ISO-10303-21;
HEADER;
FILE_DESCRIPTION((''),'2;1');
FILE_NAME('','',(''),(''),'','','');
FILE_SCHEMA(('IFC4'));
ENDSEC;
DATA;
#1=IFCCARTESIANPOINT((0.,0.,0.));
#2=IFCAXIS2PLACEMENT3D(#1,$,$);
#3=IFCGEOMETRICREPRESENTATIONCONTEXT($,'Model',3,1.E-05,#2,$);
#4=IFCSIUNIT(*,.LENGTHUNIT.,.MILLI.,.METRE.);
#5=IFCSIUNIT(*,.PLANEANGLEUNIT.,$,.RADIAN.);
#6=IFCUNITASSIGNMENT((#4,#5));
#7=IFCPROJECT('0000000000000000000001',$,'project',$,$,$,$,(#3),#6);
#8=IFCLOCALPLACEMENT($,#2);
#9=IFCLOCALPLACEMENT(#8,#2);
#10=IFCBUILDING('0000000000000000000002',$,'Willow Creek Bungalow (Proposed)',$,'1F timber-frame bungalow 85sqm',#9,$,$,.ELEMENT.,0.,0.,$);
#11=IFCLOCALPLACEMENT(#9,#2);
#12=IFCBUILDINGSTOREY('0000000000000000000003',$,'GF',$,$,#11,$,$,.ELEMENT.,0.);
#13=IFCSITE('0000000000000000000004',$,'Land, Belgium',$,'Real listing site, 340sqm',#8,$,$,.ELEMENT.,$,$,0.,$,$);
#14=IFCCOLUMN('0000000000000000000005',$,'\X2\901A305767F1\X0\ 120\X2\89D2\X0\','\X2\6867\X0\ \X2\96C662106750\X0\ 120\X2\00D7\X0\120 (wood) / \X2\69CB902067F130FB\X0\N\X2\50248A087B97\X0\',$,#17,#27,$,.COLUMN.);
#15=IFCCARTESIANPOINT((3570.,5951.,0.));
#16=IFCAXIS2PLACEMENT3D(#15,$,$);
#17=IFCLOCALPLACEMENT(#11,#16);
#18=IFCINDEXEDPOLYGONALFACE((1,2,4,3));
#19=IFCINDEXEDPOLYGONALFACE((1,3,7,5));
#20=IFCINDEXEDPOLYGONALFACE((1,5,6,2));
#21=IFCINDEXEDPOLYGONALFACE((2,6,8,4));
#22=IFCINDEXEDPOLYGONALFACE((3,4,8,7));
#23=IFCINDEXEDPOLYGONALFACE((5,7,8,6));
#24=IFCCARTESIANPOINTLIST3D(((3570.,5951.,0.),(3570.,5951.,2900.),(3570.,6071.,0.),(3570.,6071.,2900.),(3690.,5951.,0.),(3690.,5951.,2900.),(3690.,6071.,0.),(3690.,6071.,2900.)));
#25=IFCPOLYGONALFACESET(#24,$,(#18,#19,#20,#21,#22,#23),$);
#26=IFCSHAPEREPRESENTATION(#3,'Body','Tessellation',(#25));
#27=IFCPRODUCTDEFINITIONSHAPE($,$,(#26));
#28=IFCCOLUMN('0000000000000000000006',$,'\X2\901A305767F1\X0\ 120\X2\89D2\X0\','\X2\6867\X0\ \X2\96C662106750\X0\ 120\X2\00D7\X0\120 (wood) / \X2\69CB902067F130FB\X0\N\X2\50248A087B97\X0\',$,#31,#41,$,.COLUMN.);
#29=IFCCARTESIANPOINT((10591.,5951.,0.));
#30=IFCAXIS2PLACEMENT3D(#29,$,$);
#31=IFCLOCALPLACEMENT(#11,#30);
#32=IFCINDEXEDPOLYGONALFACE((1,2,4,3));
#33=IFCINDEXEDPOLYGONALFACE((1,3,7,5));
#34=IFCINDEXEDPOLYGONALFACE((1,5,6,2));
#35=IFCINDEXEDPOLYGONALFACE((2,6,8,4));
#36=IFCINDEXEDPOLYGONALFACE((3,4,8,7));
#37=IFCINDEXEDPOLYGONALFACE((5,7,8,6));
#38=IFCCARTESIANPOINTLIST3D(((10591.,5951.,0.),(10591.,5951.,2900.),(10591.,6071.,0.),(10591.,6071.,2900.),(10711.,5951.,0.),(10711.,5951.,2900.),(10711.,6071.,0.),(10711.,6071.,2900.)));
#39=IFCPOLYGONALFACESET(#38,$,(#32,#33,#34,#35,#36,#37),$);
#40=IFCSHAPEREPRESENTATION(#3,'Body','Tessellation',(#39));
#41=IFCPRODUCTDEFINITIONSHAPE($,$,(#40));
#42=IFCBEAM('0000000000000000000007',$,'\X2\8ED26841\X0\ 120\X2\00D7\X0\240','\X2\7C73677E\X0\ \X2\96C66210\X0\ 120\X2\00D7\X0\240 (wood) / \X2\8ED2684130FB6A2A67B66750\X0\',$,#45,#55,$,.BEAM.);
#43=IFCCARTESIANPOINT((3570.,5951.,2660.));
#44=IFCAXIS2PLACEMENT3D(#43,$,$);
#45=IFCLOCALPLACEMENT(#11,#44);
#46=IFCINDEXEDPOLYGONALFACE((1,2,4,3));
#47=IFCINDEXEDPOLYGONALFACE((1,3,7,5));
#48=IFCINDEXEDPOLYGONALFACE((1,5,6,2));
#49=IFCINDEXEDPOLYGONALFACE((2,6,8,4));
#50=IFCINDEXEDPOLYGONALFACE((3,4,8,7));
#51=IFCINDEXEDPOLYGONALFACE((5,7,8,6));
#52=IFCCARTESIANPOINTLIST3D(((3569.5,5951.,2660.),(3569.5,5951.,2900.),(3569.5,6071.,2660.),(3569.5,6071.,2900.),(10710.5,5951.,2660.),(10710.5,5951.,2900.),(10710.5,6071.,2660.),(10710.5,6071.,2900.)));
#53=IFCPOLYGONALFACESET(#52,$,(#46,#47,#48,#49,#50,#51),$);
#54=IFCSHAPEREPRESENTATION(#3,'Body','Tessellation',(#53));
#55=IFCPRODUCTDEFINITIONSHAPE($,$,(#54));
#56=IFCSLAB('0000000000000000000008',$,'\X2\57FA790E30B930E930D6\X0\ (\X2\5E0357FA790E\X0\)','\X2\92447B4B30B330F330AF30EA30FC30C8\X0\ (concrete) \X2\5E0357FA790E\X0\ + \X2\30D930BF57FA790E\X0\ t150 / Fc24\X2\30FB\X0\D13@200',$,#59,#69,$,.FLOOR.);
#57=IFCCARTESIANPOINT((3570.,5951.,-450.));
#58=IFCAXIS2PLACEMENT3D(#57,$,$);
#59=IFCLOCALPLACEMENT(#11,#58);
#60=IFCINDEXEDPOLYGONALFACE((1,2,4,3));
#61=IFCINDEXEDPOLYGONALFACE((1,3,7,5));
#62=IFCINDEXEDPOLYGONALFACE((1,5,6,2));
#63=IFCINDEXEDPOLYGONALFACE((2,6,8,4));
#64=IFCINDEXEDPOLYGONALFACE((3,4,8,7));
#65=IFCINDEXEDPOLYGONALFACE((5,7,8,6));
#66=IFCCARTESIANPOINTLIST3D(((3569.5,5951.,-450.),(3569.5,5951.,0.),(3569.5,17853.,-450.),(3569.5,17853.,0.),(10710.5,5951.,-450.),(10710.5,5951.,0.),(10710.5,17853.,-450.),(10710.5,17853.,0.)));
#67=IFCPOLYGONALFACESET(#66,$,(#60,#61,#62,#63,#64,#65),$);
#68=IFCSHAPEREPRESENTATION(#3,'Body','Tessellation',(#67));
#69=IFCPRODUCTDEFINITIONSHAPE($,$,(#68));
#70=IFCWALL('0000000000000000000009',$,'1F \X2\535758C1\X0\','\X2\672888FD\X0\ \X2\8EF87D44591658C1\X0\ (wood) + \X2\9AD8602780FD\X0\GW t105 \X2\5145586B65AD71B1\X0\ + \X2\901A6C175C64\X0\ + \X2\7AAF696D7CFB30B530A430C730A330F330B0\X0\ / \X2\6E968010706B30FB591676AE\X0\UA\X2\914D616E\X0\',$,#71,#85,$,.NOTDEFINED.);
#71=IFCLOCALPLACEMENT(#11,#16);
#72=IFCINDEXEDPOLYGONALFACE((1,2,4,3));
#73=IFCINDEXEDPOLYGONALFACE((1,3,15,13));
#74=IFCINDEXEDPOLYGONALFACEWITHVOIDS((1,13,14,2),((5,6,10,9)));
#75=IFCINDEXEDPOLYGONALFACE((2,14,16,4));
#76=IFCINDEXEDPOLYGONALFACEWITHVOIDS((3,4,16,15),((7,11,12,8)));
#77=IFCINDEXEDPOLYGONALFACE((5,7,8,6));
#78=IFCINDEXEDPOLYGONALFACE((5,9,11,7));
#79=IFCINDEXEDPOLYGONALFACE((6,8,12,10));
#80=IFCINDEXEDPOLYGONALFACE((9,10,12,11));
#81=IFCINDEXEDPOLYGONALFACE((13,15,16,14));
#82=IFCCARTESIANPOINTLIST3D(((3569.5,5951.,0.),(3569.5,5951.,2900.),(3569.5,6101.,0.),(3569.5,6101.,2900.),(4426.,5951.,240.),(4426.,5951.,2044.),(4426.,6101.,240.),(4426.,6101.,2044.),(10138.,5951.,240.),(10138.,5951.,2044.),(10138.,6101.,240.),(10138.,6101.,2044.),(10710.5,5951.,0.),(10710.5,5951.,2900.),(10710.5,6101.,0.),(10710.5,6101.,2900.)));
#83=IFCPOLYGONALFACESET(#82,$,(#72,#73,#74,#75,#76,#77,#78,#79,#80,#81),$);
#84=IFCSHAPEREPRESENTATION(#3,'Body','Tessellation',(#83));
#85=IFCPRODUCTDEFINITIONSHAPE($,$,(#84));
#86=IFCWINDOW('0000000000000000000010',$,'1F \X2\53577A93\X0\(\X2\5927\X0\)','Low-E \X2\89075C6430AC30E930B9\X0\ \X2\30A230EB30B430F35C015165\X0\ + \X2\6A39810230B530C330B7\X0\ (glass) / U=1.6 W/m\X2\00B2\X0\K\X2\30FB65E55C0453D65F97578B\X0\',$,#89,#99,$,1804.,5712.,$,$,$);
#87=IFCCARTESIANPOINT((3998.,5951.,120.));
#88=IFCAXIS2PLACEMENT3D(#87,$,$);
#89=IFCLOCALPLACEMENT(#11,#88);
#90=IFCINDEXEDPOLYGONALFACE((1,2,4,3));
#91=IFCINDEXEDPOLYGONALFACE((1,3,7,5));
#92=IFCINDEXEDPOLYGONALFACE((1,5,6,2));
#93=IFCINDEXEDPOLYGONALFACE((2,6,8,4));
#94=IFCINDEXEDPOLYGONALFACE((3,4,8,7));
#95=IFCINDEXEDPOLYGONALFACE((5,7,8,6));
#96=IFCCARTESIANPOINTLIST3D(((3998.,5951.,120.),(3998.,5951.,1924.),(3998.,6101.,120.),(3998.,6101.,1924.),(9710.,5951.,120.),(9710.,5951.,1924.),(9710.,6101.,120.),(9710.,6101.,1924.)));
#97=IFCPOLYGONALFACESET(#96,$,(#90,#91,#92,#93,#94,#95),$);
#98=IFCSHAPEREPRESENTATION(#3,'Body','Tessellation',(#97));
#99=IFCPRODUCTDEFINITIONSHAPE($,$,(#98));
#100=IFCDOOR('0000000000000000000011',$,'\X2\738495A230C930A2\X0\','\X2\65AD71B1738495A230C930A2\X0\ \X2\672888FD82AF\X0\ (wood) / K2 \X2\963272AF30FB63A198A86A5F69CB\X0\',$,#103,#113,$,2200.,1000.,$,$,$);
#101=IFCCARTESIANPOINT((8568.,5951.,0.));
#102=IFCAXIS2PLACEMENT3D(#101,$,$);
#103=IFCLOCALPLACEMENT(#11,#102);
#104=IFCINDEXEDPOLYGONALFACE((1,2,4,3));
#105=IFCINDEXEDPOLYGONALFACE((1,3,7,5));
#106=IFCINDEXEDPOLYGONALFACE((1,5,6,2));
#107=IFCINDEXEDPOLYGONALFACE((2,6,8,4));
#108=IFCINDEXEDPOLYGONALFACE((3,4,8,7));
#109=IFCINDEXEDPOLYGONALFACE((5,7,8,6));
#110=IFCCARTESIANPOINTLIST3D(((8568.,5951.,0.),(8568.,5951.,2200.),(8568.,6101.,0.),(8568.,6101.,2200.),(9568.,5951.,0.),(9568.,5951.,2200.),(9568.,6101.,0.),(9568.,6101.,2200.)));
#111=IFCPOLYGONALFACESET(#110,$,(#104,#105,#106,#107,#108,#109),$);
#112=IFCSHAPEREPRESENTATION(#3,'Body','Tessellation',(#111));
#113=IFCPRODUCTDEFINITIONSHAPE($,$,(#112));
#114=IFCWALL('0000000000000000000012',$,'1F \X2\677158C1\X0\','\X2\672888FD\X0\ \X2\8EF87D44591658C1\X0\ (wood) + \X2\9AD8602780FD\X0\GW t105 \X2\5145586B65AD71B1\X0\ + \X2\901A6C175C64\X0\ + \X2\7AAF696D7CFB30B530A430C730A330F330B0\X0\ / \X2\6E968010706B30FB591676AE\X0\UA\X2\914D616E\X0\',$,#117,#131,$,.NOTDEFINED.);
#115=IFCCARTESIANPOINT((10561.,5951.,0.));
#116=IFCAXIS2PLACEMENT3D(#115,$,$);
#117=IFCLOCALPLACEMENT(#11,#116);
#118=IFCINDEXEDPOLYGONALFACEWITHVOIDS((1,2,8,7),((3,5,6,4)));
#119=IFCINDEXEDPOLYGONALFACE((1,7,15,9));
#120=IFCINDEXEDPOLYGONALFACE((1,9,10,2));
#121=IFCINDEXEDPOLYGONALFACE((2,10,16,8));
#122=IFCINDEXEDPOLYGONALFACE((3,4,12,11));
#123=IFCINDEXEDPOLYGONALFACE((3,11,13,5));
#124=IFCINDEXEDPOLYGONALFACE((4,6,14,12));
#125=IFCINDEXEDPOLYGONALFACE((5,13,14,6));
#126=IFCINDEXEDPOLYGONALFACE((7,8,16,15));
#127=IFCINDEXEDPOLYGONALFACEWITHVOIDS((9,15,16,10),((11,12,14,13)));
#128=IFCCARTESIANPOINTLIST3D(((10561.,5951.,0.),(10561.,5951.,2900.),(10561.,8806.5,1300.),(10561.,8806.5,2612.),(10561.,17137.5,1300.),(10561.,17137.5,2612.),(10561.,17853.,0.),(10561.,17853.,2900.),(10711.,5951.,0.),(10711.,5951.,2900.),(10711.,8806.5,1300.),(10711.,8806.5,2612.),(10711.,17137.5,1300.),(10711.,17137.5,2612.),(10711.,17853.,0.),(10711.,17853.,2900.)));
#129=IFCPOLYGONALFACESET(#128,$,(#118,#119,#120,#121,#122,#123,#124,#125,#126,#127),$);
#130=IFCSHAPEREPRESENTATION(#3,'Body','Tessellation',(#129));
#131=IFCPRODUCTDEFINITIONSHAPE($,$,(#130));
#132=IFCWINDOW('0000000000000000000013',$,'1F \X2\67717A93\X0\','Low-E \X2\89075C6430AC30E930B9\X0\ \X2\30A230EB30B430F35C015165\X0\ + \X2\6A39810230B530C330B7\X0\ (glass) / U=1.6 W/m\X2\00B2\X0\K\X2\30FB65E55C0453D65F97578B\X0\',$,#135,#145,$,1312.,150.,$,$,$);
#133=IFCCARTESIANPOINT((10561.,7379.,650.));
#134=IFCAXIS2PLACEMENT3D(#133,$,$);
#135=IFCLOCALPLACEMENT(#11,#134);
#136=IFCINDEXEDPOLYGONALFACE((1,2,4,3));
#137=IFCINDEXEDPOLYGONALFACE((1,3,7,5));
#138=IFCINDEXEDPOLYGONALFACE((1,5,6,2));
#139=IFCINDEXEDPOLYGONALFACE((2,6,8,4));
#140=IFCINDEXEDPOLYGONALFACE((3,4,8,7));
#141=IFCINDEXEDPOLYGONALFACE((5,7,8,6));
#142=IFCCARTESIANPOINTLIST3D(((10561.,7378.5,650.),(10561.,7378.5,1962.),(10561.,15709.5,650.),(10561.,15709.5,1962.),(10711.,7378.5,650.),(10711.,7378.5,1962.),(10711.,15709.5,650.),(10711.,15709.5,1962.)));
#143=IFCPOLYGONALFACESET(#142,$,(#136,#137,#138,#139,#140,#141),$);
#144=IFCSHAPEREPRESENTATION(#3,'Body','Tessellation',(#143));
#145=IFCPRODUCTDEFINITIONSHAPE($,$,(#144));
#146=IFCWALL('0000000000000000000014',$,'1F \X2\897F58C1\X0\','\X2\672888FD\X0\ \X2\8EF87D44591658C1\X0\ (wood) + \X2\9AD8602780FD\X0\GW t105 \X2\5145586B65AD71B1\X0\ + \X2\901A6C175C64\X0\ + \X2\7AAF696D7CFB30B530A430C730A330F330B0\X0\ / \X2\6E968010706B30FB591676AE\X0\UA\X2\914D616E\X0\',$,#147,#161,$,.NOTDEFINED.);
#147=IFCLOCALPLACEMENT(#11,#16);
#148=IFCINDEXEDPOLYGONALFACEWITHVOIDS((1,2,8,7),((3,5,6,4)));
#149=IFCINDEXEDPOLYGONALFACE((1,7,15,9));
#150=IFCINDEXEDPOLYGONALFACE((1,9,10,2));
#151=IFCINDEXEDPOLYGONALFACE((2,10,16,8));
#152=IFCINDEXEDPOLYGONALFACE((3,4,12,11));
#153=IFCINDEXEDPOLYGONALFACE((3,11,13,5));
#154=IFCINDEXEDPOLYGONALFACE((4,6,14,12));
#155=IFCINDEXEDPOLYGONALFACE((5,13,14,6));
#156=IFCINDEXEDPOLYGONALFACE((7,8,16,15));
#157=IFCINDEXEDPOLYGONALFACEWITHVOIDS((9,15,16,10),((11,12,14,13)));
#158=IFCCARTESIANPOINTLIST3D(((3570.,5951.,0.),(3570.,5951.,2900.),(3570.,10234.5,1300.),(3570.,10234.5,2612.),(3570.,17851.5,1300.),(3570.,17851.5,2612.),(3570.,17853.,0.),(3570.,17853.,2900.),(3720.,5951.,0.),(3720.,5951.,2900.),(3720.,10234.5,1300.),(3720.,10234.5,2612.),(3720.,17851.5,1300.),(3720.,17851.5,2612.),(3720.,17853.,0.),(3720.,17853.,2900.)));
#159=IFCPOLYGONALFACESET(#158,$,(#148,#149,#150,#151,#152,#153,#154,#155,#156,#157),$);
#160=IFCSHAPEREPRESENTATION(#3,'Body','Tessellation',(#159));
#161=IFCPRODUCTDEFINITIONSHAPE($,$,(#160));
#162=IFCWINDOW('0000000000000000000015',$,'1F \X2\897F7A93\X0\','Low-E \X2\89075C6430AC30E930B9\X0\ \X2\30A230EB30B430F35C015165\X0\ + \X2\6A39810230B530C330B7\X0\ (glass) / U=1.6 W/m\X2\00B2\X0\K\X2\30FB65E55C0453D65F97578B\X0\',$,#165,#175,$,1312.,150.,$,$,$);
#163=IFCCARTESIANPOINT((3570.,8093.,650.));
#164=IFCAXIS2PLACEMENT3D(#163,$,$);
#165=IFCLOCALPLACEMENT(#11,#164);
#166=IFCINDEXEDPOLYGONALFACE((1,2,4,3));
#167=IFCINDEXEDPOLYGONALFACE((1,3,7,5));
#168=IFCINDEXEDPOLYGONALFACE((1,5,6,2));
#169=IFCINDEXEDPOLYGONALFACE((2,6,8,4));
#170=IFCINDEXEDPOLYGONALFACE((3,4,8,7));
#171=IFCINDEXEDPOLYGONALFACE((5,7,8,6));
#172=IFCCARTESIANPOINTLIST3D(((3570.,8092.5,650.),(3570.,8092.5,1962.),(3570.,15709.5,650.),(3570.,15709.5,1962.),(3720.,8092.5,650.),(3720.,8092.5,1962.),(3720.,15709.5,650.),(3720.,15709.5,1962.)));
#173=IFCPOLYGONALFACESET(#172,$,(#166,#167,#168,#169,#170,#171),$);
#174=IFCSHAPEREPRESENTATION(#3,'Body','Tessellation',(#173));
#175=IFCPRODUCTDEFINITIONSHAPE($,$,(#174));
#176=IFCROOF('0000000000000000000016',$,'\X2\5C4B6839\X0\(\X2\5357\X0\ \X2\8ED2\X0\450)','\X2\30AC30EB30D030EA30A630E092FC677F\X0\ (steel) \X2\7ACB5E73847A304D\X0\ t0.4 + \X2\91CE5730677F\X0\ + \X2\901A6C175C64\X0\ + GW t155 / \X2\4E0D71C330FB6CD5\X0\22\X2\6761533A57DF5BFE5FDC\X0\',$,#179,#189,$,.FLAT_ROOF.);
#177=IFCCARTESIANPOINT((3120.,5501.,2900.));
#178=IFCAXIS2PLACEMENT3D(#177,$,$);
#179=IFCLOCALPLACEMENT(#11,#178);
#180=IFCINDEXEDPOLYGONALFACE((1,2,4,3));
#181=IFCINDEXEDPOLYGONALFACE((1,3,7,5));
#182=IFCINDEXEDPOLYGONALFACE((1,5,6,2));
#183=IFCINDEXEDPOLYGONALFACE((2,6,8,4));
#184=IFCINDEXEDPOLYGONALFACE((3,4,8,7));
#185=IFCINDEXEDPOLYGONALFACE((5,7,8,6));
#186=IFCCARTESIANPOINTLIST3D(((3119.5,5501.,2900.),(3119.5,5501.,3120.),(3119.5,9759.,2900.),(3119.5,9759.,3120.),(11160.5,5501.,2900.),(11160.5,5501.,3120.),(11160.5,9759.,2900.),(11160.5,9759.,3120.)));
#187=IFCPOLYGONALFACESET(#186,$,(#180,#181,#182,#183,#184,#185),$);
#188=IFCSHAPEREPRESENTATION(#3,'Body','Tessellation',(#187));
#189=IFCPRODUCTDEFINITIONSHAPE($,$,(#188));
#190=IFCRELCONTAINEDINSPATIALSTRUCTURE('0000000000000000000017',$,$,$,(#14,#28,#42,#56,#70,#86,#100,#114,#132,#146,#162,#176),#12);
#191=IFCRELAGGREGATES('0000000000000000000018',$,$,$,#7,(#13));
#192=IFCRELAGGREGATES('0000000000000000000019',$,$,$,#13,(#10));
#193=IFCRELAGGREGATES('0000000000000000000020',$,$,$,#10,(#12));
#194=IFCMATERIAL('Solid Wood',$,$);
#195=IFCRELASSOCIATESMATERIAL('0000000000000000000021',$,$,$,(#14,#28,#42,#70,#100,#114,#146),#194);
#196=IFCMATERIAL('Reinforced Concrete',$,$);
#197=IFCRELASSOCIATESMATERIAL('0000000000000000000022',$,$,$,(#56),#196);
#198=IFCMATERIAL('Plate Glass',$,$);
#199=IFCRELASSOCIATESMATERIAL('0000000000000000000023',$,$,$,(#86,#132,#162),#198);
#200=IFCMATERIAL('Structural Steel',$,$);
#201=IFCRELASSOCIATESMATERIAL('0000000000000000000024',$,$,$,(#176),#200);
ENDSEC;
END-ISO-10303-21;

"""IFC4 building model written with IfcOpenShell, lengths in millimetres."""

from ifc_helpers import new_model, si_unit, frame, frame_2d, origin, place, context, project, spatial, rectangle, extrude, material, element, fill, save


model = new_model("IFC4")

# Units and contexts
model_context = context("Model", 3, precision=1e-05, world=origin())
ifc_project = project(units=[si_unit("LENGTHUNIT", "METRE", prefix="MILLI"), si_unit("PLANEANGLEUNIT", "RADIAN")], contexts=[model_context])

# Site, building, storey
site_placement = place(None, origin())
site = spatial("IfcSite", under=ifc_project, at=site_placement, Name="Land, Belgium", ObjectType="Real listing site, 340sqm", CompositionType="ELEMENT", RefElevation=0.0)
building_placement = place(site_placement, origin())
building = spatial("IfcBuilding", under=site, at=building_placement, Name="Willow Creek Bungalow (Proposed)", ObjectType="1F timber-frame bungalow 85sqm", CompositionType="ELEMENT", ElevationOfRefHeight=0.0, ElevationOfTerrain=0.0)
storey_placement = place(building_placement, origin())
storey = spatial("IfcBuildingStorey", under=building, at=storey_placement, Name="GF", CompositionType="ELEMENT", Elevation=0.0)

# Columns
ifc_material_1 = material(Name="Solid Wood")
column_1_placement = place(storey_placement, frame((3570.0, 5951.0, 0.0)))
element("IfcColumn", 1, at=column_1_placement, inside=storey, material=ifc_material_1, Name="通し柱 120角", Description="桧 集成材 120×120 (wood) / 構造柱・N値計算", PredefinedType="COLUMN", context=model_context, shape_type="SweptSolid", body=[
    extrude(rectangle(XDim=120.0, YDim=120.0, at=frame_2d((60.0, 60.0))), frame((3570.0, 5951.0, 0.0)), (0.0, 0.0, 1.0), 2900.0),
])
column_2_placement = place(storey_placement, frame((10591.0, 5951.0, 0.0)))
element("IfcColumn", 2, at=column_2_placement, inside=storey, material=ifc_material_1, Name="通し柱 120角", Description="桧 集成材 120×120 (wood) / 構造柱・N値計算", PredefinedType="COLUMN", context=model_context, shape_type="SweptSolid", body=[
    extrude(rectangle(XDim=120.0, YDim=120.0, at=frame_2d((60.0, 60.0))), frame((10591.0, 5951.0, 0.0)), (0.0, 0.0, 1.0), 2900.0),
])

# Beam
beam_1_placement = place(storey_placement, frame((3570.0, 5951.0, 2660.0)))
element("IfcBeam", 3, at=beam_1_placement, inside=storey, material=ifc_material_1, Name="軒桁 120×240", Description="米松 集成 120×240 (wood) / 軒桁・横架材", PredefinedType="BEAM", context=model_context, shape_type="SweptSolid", body=[
    extrude(rectangle(XDim=7141.0, YDim=120.0, at=frame_2d((3570.0, 60.0))), frame((3570.0, 5951.0, 2660.0)), (0.0, 0.0, 1.0), 240.0),
])

# Slab
ifc_material_2 = material(Name="Reinforced Concrete")
slab_1_placement = place(storey_placement, frame((3570.0, 5951.0, -450.0)))
element("IfcSlab", 4, at=slab_1_placement, inside=storey, material=ifc_material_2, Name="基礎スラブ (布基礎)", Description="鉄筋コンクリート (concrete) 布基礎 + ベタ基礎 t150 / Fc24・D13@200", PredefinedType="FLOOR", context=model_context, shape_type="SweptSolid", body=[
    extrude(rectangle(XDim=7141.0, YDim=11902.0, at=frame_2d((3570.0, 5951.0))), frame((3570.0, 5951.0, -450.0)), (0.0, 0.0, 1.0), 450.0),
])

# Wall, openings, window, door
wall_1_placement = place(storey_placement, frame((3570.0, 5951.0, 0.0)))
wall_1 = element("IfcWall", 5, at=wall_1_placement, inside=storey, material=ifc_material_1, Name="1F 南壁", Description="木製 軸組外壁 (wood) + 高性能GW t105 充填断熱 + 通気層 + 窯業系サイディング / 準耐火・外皮UA配慮", PredefinedType="NOTDEFINED", context=model_context, shape_type="SweptSolid", body=[
    extrude(rectangle(XDim=7141.0, YDim=150.0, at=frame_2d((3570.0, 75.0))), frame((3570.0, 5951.0, 0.0)), (0.0, 0.0, 1.0), 2900.0),
])
opening_1_placement = place(storey_placement, frame((3998.0, 5951.0, 120.0)))
opening_1 = element("IfcOpeningElement", 6, at=opening_1_placement, cuts=wall_1, PredefinedType="NOTDEFINED", context=model_context, shape_type="SweptSolid", body=[
    extrude(rectangle(XDim=5712.0, YDim=150.0, at=frame_2d((2856.0, 75.0))), frame((3998.0, 5951.0, 120.0)), (0.0, 0.0, 1.0), 1804.0),
])
opening_2_placement = place(storey_placement, frame((8568.0, 5951.0, 0.0)))
opening_2 = element("IfcOpeningElement", 7, at=opening_2_placement, cuts=wall_1, PredefinedType="NOTDEFINED", context=model_context, shape_type="SweptSolid", body=[
    extrude(rectangle(XDim=1000.0, YDim=150.0, at=frame_2d((500.0, 75.0))), frame((8568.0, 5951.0, 0.0)), (0.0, 0.0, 1.0), 2200.0),
])
ifc_material_3 = material(Name="Plate Glass")
window_1_placement = place(storey_placement, frame((3998.0, 5951.0, 120.0)))
window_1 = element("IfcWindow", 8, at=window_1_placement, inside=storey, material=ifc_material_3, Name="1F 南窓(大)", Description="Low-E 複層ガラス アルゴン封入 + 樹脂サッシ (glass) / U=1.6 W/m²K・日射取得型", OverallHeight=1804.0, OverallWidth=5712.0, context=model_context, shape_type="SweptSolid", body=[
    extrude(rectangle(XDim=5712.0, YDim=150.0, at=frame_2d((2856.0, 75.0))), frame((3998.0, 5951.0, 120.0)), (0.0, 0.0, 1.0), 1804.0),
])
fill(opening_1, window_1)
door_placement = place(storey_placement, frame((8568.0, 5951.0, 0.0)))
door = element("IfcDoor", 9, at=door_placement, inside=storey, material=ifc_material_1, Name="玄関ドア", Description="断熱玄関ドア 木製芯 (wood) / K2 防犯・採風機構", OverallHeight=2200.0, OverallWidth=1000.0, context=model_context, shape_type="SweptSolid", body=[
    extrude(rectangle(XDim=1000.0, YDim=150.0, at=frame_2d((500.0, 75.0))), frame((8568.0, 5951.0, 0.0)), (0.0, 0.0, 1.0), 2200.0),
])
fill(opening_2, door)

# Walls, openings, windows
wall_2_placement = place(storey_placement, frame((10561.0, 5951.0, 0.0)))
wall_2 = element("IfcWall", 10, at=wall_2_placement, inside=storey, material=ifc_material_1, Name="1F 東壁", Description="木製 軸組外壁 (wood) + 高性能GW t105 充填断熱 + 通気層 + 窯業系サイディング / 準耐火・外皮UA配慮", PredefinedType="NOTDEFINED", context=model_context, shape_type="SweptSolid", body=[
    extrude(rectangle(XDim=150.0, YDim=11902.0, at=frame_2d((75.0, 5951.0))), frame((10561.0, 5951.0, 0.0)), (0.0, 0.0, 1.0), 2900.0),
])
opening_3_placement = place(storey_placement, frame((10561.0, 7379.0, 650.0)))
opening_3 = element("IfcOpeningElement", 11, at=opening_3_placement, cuts=wall_2, PredefinedType="NOTDEFINED", context=model_context, shape_type="SweptSolid", body=[
    extrude(rectangle(XDim=150.0, YDim=8331.0, at=frame_2d((75.0, 4165.0))), frame((10561.0, 7379.0, 650.0)), (0.0, 0.0, 1.0), 1312.0),
])
window_2_placement = place(storey_placement, frame((10561.0, 7379.0, 650.0)))
window_2 = element("IfcWindow", 12, at=window_2_placement, inside=storey, material=ifc_material_3, Name="1F 東窓", Description="Low-E 複層ガラス アルゴン封入 + 樹脂サッシ (glass) / U=1.6 W/m²K・日射取得型", OverallHeight=1312.0, OverallWidth=150.0, context=model_context, shape_type="SweptSolid", body=[
    extrude(rectangle(XDim=150.0, YDim=8331.0, at=frame_2d((75.0, 4165.0))), frame((10561.0, 7379.0, 650.0)), (0.0, 0.0, 1.0), 1312.0),
])
fill(opening_3, window_2)
wall_3_placement = place(storey_placement, frame((3570.0, 5951.0, 0.0)))
wall_3 = element("IfcWall", 13, at=wall_3_placement, inside=storey, material=ifc_material_1, Name="1F 西壁", Description="木製 軸組外壁 (wood) + 高性能GW t105 充填断熱 + 通気層 + 窯業系サイディング / 準耐火・外皮UA配慮", PredefinedType="NOTDEFINED", context=model_context, shape_type="SweptSolid", body=[
    extrude(rectangle(XDim=150.0, YDim=11902.0, at=frame_2d((75.0, 5951.0))), frame((3570.0, 5951.0, 0.0)), (0.0, 0.0, 1.0), 2900.0),
])
opening_4_placement = place(storey_placement, frame((3570.0, 8093.0, 650.0)))
opening_4 = element("IfcOpeningElement", 14, at=opening_4_placement, cuts=wall_3, PredefinedType="NOTDEFINED", context=model_context, shape_type="SweptSolid", body=[
    extrude(rectangle(XDim=150.0, YDim=7617.0, at=frame_2d((75.0, 3808.0))), frame((3570.0, 8093.0, 650.0)), (0.0, 0.0, 1.0), 1312.0),
])
window_3_placement = place(storey_placement, frame((3570.0, 8093.0, 650.0)))
window_3 = element("IfcWindow", 15, at=window_3_placement, inside=storey, material=ifc_material_3, Name="1F 西窓", Description="Low-E 複層ガラス アルゴン封入 + 樹脂サッシ (glass) / U=1.6 W/m²K・日射取得型", OverallHeight=1312.0, OverallWidth=150.0, context=model_context, shape_type="SweptSolid", body=[
    extrude(rectangle(XDim=150.0, YDim=7617.0, at=frame_2d((75.0, 3808.0))), frame((3570.0, 8093.0, 650.0)), (0.0, 0.0, 1.0), 1312.0),
])
fill(opening_4, window_3)

# Roof
ifc_material_4 = material(Name="Structural Steel")
roof_placement = place(storey_placement, frame((3120.0, 5501.0, 2900.0)))
element("IfcRoof", 16, at=roof_placement, inside=storey, material=ifc_material_4, Name="屋根(南 軒450)", Description="ガルバリウム鋼板 (steel) 立平葺き t0.4 + 野地板 + 通気層 + GW t155 / 不燃・法22条区域対応", PredefinedType="FLAT_ROOF", context=model_context, shape_type="SweptSolid", body=[
    extrude(rectangle(XDim=8041.0, YDim=4258.0, at=frame_2d((4020.0, 2129.0))), frame((3120.0, 5501.0, 2900.0)), (0.0, 0.0, 1.0), 220.0),
])

save(model, "model.ifc")
